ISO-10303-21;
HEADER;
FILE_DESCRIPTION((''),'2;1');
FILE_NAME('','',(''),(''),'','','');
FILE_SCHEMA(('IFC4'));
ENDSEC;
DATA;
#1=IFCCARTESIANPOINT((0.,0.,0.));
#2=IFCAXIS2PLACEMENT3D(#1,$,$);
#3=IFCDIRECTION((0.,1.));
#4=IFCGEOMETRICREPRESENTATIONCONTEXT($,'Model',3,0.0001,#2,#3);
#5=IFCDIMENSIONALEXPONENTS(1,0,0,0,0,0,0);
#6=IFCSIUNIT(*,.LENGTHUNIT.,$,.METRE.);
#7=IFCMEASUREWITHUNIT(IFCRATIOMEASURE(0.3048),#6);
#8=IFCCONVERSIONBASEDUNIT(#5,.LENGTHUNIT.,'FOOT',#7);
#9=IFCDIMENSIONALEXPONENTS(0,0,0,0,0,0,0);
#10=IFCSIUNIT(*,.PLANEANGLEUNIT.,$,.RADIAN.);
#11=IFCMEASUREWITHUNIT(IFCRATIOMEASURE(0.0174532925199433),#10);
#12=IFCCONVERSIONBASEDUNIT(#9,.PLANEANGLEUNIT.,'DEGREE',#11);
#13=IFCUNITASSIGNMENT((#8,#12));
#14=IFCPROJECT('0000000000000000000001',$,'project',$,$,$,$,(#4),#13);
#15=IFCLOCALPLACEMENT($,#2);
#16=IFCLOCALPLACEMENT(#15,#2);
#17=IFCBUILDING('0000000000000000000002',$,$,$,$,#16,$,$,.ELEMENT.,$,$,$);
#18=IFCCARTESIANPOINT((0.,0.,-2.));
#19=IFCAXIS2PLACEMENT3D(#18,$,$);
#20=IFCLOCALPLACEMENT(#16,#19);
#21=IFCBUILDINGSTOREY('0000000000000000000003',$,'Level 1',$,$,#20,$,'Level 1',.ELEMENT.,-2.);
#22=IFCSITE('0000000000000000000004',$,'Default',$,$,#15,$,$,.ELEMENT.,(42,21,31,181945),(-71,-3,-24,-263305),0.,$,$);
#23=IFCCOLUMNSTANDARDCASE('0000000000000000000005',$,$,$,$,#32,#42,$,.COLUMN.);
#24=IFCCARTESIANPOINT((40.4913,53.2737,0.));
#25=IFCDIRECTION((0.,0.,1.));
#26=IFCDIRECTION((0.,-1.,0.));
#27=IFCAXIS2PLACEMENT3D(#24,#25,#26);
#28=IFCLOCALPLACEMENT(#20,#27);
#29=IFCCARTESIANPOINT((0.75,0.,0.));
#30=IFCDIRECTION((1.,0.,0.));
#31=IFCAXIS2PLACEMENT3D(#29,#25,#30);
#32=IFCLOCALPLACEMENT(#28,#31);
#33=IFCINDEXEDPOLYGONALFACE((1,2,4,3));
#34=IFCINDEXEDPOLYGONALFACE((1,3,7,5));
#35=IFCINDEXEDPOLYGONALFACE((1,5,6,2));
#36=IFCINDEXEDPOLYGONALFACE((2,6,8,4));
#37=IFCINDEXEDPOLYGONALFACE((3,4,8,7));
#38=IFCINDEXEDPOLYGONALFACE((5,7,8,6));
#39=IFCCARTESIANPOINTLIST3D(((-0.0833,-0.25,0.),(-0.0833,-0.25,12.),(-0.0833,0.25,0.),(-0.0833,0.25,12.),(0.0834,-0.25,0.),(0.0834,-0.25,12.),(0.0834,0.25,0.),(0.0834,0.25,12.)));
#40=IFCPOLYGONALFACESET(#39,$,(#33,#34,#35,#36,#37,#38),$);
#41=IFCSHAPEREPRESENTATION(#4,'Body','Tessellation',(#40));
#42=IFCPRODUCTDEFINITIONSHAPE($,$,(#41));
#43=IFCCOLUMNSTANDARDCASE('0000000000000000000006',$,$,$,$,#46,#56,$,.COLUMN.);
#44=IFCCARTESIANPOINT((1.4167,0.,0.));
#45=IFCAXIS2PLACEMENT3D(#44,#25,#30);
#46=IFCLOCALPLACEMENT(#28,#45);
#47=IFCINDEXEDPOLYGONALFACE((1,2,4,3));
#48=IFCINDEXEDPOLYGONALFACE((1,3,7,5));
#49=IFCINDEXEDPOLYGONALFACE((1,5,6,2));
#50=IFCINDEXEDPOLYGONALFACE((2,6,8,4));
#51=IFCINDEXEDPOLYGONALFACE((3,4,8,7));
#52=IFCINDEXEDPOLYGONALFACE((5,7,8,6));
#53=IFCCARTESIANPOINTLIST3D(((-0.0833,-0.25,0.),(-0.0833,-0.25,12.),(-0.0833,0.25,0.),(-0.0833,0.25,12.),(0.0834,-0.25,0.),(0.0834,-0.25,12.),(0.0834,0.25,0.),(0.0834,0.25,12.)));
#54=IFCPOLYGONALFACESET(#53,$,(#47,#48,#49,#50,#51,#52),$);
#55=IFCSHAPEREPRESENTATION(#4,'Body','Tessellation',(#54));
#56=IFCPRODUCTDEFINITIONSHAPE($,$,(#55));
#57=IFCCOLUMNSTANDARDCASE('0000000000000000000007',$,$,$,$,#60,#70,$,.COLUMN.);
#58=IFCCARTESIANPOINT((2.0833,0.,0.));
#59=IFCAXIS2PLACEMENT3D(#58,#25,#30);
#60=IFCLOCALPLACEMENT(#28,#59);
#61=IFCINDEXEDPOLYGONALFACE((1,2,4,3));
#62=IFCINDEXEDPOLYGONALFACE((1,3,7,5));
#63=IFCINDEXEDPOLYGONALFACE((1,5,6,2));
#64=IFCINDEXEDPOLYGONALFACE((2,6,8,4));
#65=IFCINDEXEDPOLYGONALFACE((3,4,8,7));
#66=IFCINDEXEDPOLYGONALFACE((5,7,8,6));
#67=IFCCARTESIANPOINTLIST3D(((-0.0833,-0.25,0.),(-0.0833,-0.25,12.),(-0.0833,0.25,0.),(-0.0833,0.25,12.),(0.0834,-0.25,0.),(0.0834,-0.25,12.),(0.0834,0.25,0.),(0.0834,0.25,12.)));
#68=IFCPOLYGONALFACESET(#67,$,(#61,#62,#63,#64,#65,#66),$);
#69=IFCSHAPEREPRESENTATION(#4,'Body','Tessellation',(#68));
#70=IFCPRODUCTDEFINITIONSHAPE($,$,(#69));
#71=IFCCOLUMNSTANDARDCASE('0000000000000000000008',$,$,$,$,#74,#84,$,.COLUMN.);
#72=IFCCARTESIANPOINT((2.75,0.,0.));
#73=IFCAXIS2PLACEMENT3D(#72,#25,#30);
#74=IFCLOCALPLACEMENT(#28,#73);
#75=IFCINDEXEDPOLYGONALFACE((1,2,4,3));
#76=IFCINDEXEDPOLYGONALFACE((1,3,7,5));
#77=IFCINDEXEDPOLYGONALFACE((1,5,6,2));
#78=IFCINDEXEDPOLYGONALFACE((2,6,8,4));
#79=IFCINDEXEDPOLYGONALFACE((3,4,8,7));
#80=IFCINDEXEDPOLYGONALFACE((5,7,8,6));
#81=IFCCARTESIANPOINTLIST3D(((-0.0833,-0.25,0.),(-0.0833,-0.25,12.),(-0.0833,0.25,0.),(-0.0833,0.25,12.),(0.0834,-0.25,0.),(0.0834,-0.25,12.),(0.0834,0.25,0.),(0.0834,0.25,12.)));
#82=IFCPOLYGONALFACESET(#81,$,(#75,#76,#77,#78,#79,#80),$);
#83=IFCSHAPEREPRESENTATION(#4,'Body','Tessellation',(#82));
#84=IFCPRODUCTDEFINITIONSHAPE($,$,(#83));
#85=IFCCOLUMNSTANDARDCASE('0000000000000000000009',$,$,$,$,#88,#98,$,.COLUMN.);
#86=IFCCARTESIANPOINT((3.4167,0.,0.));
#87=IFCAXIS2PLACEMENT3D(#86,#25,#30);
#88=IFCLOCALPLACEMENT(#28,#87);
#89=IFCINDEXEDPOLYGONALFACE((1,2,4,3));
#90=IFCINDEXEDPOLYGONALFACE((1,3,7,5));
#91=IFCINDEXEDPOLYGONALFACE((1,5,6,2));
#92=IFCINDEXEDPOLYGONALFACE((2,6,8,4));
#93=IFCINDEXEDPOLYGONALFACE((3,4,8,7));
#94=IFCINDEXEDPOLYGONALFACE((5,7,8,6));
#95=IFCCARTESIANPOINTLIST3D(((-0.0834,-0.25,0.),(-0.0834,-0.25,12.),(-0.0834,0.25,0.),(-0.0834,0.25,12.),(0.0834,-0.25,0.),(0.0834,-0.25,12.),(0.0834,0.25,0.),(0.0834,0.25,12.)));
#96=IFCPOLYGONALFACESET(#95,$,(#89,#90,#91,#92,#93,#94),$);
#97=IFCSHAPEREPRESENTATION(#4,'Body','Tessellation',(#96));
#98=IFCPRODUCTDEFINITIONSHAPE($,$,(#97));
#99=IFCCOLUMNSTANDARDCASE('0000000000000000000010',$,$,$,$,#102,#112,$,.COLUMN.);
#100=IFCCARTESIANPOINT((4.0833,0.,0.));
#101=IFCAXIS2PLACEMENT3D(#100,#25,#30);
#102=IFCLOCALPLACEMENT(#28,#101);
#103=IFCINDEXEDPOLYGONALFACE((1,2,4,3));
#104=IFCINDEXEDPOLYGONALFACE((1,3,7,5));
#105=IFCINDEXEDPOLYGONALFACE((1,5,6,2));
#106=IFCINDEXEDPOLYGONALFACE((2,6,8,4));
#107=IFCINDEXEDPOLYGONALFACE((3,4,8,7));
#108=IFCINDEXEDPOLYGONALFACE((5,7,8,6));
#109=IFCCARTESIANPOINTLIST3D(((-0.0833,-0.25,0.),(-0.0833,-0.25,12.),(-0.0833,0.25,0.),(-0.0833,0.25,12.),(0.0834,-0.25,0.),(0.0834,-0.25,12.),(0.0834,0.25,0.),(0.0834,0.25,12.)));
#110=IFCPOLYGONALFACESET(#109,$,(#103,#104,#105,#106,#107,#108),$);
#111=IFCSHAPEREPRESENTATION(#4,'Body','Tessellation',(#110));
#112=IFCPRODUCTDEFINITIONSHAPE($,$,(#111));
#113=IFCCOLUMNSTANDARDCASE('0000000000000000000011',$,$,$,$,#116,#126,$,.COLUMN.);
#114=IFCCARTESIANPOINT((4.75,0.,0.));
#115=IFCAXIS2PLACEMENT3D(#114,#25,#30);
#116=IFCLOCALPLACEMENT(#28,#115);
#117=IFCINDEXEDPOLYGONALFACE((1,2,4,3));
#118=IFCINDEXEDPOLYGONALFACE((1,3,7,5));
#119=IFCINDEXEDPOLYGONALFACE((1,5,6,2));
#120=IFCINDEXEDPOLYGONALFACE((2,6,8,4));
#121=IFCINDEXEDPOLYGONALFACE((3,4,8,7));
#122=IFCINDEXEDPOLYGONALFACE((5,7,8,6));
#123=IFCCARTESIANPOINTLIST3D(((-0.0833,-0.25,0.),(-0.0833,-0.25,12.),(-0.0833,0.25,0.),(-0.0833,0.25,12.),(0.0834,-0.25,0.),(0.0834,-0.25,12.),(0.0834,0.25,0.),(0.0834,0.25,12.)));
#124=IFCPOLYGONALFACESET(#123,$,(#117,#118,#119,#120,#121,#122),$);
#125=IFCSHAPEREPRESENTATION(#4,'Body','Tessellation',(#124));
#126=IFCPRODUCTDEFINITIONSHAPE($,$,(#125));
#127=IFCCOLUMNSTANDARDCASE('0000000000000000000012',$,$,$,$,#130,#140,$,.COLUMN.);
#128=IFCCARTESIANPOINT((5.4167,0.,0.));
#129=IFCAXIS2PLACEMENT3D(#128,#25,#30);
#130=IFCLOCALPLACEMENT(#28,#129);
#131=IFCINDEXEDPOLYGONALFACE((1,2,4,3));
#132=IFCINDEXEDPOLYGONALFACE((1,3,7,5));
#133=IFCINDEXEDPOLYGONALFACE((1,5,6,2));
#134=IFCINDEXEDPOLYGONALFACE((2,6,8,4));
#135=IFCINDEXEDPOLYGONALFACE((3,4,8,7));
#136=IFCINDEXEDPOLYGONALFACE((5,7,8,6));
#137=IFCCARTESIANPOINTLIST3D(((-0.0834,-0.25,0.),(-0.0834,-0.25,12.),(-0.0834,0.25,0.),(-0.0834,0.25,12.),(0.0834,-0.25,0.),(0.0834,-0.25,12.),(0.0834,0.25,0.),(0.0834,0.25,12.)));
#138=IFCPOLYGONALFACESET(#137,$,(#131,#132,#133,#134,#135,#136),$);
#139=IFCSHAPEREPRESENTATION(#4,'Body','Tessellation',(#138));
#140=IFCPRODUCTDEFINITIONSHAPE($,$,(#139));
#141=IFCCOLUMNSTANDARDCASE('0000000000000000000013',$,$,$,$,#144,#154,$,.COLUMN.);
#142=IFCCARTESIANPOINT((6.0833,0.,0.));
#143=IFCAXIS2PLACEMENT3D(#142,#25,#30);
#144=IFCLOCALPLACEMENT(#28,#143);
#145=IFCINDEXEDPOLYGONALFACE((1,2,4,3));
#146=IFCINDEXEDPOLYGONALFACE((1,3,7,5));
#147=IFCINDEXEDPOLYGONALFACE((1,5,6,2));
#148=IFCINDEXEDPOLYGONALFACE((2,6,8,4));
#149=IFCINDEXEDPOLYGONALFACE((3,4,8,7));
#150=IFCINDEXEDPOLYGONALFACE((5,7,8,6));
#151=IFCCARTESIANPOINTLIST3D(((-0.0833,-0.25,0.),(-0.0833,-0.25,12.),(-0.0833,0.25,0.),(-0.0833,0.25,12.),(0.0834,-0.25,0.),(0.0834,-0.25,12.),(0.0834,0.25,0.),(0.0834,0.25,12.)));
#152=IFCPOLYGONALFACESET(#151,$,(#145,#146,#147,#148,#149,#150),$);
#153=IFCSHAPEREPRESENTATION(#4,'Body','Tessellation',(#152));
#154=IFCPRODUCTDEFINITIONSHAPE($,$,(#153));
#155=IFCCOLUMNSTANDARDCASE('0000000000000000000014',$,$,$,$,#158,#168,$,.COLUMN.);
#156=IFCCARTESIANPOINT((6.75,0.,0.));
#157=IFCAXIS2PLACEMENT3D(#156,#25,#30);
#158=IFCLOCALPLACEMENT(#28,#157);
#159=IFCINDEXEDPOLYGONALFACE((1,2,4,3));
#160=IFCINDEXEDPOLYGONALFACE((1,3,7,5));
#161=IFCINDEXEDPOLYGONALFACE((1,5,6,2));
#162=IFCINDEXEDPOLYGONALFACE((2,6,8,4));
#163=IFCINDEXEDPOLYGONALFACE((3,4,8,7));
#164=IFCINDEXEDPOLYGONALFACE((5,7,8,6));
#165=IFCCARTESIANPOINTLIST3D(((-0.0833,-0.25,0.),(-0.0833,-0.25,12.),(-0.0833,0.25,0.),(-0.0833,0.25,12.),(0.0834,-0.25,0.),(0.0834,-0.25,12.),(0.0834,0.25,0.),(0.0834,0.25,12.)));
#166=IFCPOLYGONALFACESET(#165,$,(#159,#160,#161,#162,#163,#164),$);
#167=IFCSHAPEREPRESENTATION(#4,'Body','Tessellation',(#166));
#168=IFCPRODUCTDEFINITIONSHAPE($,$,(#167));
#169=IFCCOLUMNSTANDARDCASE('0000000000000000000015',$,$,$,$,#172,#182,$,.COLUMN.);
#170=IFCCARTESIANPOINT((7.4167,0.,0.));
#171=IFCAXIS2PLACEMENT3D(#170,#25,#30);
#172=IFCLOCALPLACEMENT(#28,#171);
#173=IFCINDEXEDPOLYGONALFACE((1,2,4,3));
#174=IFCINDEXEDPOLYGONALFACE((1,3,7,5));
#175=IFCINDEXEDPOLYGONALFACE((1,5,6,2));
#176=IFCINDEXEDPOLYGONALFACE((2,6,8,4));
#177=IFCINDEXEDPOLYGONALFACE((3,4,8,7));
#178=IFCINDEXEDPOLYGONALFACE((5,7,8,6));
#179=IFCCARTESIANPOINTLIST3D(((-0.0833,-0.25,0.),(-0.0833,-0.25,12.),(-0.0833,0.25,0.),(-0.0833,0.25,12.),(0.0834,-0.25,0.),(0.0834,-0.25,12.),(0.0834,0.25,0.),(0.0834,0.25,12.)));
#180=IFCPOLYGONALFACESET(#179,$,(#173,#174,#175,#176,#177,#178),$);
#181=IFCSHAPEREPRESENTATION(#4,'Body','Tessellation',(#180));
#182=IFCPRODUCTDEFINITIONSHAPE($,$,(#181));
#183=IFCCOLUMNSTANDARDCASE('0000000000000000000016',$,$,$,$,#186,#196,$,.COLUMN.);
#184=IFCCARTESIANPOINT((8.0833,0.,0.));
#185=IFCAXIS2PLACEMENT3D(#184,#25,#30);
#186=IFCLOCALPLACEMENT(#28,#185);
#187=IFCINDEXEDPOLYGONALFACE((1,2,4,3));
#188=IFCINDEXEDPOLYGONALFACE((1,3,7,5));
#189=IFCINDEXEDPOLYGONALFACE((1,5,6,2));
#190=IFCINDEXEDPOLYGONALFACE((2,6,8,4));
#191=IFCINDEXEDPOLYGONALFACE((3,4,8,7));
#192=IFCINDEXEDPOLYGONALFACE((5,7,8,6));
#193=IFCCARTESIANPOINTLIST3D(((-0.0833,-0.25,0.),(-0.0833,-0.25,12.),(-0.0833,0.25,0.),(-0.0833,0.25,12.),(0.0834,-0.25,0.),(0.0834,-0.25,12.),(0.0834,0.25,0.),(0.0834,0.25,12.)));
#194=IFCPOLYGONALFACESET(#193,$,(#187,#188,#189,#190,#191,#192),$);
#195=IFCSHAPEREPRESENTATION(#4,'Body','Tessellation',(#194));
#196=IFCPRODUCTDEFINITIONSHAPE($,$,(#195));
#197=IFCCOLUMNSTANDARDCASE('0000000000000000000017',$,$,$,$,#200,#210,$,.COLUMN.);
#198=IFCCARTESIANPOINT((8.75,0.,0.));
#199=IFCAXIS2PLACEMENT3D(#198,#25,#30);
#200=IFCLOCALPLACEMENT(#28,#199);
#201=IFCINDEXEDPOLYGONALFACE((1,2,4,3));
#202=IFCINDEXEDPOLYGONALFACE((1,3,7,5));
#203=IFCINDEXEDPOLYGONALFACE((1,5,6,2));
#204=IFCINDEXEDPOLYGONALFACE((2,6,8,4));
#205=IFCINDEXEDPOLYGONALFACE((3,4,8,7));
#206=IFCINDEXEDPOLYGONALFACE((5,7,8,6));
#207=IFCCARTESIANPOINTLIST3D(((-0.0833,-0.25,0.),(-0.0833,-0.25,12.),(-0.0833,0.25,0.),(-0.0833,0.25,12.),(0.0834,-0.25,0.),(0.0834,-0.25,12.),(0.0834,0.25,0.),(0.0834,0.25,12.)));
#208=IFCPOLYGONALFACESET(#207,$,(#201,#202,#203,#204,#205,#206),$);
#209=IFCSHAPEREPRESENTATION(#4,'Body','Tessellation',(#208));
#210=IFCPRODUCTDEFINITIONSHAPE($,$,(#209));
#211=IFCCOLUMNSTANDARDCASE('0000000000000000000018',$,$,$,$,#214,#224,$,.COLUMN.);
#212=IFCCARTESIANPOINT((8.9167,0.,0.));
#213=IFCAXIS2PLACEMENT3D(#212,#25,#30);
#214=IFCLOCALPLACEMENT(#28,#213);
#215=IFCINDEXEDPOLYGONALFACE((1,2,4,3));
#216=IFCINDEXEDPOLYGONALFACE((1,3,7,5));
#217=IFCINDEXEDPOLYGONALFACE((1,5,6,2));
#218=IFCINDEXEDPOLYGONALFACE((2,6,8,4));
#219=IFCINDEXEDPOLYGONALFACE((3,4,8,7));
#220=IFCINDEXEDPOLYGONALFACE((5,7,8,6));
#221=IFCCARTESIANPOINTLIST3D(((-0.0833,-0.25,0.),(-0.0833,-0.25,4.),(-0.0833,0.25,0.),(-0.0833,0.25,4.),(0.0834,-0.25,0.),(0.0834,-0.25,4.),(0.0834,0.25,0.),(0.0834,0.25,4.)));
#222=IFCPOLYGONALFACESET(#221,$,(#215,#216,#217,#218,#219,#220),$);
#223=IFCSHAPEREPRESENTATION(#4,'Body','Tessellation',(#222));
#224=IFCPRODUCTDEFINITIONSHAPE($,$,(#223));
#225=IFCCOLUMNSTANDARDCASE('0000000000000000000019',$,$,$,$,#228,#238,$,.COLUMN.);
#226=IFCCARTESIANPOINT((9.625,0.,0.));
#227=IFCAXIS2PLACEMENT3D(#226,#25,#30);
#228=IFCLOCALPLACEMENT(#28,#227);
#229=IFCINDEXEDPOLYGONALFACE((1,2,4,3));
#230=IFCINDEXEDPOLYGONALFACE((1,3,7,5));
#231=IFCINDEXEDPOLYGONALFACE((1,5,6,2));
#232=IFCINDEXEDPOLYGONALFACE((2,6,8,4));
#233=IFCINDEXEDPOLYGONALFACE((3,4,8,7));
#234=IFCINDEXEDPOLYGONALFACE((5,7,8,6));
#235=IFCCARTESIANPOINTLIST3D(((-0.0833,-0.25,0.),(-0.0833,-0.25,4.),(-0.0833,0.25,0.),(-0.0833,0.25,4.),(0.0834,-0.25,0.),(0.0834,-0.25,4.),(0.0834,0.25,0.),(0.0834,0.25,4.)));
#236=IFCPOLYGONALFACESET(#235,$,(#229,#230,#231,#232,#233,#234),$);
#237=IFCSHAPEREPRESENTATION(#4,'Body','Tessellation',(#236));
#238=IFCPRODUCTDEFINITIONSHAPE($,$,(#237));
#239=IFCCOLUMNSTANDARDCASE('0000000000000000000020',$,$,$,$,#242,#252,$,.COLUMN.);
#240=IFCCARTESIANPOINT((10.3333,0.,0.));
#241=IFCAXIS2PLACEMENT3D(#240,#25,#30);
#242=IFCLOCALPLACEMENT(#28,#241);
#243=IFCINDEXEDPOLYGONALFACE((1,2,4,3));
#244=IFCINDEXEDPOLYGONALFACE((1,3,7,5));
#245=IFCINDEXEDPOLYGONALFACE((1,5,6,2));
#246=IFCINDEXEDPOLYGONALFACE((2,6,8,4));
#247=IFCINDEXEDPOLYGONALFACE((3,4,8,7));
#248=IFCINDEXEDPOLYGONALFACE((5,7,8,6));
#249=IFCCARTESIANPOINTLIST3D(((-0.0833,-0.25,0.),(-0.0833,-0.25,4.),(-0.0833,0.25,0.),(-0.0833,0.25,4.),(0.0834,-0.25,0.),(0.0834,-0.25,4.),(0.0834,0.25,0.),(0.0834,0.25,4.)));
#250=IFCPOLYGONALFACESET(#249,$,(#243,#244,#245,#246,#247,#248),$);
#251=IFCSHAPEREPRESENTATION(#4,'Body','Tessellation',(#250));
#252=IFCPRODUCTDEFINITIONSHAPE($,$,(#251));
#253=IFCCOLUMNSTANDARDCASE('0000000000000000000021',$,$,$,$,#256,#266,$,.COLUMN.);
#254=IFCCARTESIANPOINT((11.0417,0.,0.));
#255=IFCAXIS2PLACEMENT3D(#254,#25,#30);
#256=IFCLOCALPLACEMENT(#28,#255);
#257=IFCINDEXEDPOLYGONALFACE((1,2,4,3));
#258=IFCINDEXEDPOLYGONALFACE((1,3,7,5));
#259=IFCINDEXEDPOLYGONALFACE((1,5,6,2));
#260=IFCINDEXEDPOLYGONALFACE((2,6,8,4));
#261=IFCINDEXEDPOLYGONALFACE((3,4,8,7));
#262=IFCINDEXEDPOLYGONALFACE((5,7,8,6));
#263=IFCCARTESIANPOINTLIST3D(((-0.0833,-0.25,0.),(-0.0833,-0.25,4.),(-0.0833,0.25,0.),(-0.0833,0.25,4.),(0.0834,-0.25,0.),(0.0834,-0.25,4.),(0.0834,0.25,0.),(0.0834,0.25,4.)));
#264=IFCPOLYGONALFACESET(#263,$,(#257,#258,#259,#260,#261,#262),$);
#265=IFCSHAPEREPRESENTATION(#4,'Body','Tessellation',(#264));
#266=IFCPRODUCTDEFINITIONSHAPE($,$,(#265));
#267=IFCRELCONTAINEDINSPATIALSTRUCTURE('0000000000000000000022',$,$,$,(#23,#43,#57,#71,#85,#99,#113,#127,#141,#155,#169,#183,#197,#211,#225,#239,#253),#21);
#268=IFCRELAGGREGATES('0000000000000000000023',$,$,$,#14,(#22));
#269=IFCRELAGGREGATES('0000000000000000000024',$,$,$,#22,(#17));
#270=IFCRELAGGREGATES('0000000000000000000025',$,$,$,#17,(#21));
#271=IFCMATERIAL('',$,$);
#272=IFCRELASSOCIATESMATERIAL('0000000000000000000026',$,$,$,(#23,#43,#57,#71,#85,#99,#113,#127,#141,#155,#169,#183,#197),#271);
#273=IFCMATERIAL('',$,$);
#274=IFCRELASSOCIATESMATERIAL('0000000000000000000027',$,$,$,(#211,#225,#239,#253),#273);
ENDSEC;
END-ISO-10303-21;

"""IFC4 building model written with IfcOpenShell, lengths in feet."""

from ifc_helpers import new_model, entity, si_unit, converted_unit, direction, frame, origin, place, context, project, spatial, rectangle, extrude, material, element, save


model = new_model("IFC4")

# Units and contexts
model_context = context("Model", 3, precision=0.0001, world=origin(), true_north=direction((0.0, 1.0)))
ifc_project = project(units=[converted_unit("LENGTHUNIT", "FOOT", entity("IfcRatioMeasure", 0.3048), si_unit("LENGTHUNIT", "METRE"), dimensions=[1, 0, 0, 0, 0, 0, 0]), converted_unit("PLANEANGLEUNIT", "DEGREE", entity("IfcRatioMeasure", 0.0174532925199433), si_unit("PLANEANGLEUNIT", "RADIAN"), dimensions=[0, 0, 0, 0, 0, 0, 0])], contexts=[model_context])

# Site, building, storey
site_placement = place(None, origin())
site = spatial("IfcSite", under=ifc_project, at=site_placement, Name="Default", CompositionType="ELEMENT", RefLatitude=(42, 21, 31, 181945), RefLongitude=(-71, -3, -24, -263305), RefElevation=0.0)
building_placement = place(site_placement, origin())
building = spatial("IfcBuilding", under=site, at=building_placement, CompositionType="ELEMENT")
storey_placement = place(building_placement, frame((0.0, 0.0, -2.0)))
storey = spatial("IfcBuildingStorey", under=building, at=storey_placement, Name="Level 1", LongName="Level 1", CompositionType="ELEMENT", Elevation=-2.0)

# Columns
ifc_material_1 = material(Name="")
placement_1 = place(storey_placement, frame((40.4913, 53.2737, 0.0), z_axis=(0.0, 0.0, 1.0), x_axis=(0.0, -1.0, 0.0)))
for number, where, z_axis, x_axis in (
    (1, (0.75, 0.0, 0.0), (0.0, 0.0, 1.0), (1.0, 0.0, 0.0)),
    (2, (1.4167, 0.0, 0.0), (0.0, 0.0, 1.0), (1.0, 0.0, 0.0)),
    (3, (2.0833, 0.0, 0.0), (0.0, 0.0, 1.0), (1.0, 0.0, 0.0)),
    (4, (2.75, 0.0, 0.0), (0.0, 0.0, 1.0), (1.0, 0.0, 0.0)),
    (5, (3.4167, 0.0, 0.0), (0.0, 0.0, 1.0), (1.0, 0.0, 0.0)),
    (6, (4.0833, 0.0, 0.0), (0.0, 0.0, 1.0), (1.0, 0.0, 0.0)),
    (7, (4.75, 0.0, 0.0), (0.0, 0.0, 1.0), (1.0, 0.0, 0.0)),
    (8, (5.4167, 0.0, 0.0), (0.0, 0.0, 1.0), (1.0, 0.0, 0.0)),
    (9, (6.0833, 0.0, 0.0), (0.0, 0.0, 1.0), (1.0, 0.0, 0.0)),
    (10, (6.75, 0.0, 0.0), (0.0, 0.0, 1.0), (1.0, 0.0, 0.0)),
    (11, (7.4167, 0.0, 0.0), (0.0, 0.0, 1.0), (1.0, 0.0, 0.0)),
    (12, (8.0833, 0.0, 0.0), (0.0, 0.0, 1.0), (1.0, 0.0, 0.0)),
    (13, (8.75, 0.0, 0.0), (0.0, 0.0, 1.0), (1.0, 0.0, 0.0)),
):
    element("IfcColumnStandardCase", number, at=place(placement_1, frame(where, z_axis=z_axis, x_axis=x_axis)), inside=storey, material=ifc_material_1, PredefinedType="COLUMN", context=model_context, shape_type="SweptSolid", body=[
        extrude(rectangle(XDim=0.1667, YDim=0.5), origin(), (0.0, 0.0, 1.0), 12.0),
    ])
ifc_material_2 = material(Name="")
for number, where, z_axis, x_axis in (
    (14, (8.9167, 0.0, 0.0), (0.0, 0.0, 1.0), (1.0, 0.0, 0.0)),
    (15, (9.625, 0.0, 0.0), (0.0, 0.0, 1.0), (1.0, 0.0, 0.0)),
    (16, (10.3333, 0.0, 0.0), (0.0, 0.0, 1.0), (1.0, 0.0, 0.0)),
    (17, (11.0417, 0.0, 0.0), (0.0, 0.0, 1.0), (1.0, 0.0, 0.0)),
):
    element("IfcColumnStandardCase", number, at=place(placement_1, frame(where, z_axis=z_axis, x_axis=x_axis)), inside=storey, material=ifc_material_2, PredefinedType="COLUMN", context=model_context, shape_type="SweptSolid", body=[
        extrude(rectangle(XDim=0.1667, YDim=0.5), origin(), (0.0, 0.0, 1.0), 4.0),
    ])

save(model, "model.ifc")
